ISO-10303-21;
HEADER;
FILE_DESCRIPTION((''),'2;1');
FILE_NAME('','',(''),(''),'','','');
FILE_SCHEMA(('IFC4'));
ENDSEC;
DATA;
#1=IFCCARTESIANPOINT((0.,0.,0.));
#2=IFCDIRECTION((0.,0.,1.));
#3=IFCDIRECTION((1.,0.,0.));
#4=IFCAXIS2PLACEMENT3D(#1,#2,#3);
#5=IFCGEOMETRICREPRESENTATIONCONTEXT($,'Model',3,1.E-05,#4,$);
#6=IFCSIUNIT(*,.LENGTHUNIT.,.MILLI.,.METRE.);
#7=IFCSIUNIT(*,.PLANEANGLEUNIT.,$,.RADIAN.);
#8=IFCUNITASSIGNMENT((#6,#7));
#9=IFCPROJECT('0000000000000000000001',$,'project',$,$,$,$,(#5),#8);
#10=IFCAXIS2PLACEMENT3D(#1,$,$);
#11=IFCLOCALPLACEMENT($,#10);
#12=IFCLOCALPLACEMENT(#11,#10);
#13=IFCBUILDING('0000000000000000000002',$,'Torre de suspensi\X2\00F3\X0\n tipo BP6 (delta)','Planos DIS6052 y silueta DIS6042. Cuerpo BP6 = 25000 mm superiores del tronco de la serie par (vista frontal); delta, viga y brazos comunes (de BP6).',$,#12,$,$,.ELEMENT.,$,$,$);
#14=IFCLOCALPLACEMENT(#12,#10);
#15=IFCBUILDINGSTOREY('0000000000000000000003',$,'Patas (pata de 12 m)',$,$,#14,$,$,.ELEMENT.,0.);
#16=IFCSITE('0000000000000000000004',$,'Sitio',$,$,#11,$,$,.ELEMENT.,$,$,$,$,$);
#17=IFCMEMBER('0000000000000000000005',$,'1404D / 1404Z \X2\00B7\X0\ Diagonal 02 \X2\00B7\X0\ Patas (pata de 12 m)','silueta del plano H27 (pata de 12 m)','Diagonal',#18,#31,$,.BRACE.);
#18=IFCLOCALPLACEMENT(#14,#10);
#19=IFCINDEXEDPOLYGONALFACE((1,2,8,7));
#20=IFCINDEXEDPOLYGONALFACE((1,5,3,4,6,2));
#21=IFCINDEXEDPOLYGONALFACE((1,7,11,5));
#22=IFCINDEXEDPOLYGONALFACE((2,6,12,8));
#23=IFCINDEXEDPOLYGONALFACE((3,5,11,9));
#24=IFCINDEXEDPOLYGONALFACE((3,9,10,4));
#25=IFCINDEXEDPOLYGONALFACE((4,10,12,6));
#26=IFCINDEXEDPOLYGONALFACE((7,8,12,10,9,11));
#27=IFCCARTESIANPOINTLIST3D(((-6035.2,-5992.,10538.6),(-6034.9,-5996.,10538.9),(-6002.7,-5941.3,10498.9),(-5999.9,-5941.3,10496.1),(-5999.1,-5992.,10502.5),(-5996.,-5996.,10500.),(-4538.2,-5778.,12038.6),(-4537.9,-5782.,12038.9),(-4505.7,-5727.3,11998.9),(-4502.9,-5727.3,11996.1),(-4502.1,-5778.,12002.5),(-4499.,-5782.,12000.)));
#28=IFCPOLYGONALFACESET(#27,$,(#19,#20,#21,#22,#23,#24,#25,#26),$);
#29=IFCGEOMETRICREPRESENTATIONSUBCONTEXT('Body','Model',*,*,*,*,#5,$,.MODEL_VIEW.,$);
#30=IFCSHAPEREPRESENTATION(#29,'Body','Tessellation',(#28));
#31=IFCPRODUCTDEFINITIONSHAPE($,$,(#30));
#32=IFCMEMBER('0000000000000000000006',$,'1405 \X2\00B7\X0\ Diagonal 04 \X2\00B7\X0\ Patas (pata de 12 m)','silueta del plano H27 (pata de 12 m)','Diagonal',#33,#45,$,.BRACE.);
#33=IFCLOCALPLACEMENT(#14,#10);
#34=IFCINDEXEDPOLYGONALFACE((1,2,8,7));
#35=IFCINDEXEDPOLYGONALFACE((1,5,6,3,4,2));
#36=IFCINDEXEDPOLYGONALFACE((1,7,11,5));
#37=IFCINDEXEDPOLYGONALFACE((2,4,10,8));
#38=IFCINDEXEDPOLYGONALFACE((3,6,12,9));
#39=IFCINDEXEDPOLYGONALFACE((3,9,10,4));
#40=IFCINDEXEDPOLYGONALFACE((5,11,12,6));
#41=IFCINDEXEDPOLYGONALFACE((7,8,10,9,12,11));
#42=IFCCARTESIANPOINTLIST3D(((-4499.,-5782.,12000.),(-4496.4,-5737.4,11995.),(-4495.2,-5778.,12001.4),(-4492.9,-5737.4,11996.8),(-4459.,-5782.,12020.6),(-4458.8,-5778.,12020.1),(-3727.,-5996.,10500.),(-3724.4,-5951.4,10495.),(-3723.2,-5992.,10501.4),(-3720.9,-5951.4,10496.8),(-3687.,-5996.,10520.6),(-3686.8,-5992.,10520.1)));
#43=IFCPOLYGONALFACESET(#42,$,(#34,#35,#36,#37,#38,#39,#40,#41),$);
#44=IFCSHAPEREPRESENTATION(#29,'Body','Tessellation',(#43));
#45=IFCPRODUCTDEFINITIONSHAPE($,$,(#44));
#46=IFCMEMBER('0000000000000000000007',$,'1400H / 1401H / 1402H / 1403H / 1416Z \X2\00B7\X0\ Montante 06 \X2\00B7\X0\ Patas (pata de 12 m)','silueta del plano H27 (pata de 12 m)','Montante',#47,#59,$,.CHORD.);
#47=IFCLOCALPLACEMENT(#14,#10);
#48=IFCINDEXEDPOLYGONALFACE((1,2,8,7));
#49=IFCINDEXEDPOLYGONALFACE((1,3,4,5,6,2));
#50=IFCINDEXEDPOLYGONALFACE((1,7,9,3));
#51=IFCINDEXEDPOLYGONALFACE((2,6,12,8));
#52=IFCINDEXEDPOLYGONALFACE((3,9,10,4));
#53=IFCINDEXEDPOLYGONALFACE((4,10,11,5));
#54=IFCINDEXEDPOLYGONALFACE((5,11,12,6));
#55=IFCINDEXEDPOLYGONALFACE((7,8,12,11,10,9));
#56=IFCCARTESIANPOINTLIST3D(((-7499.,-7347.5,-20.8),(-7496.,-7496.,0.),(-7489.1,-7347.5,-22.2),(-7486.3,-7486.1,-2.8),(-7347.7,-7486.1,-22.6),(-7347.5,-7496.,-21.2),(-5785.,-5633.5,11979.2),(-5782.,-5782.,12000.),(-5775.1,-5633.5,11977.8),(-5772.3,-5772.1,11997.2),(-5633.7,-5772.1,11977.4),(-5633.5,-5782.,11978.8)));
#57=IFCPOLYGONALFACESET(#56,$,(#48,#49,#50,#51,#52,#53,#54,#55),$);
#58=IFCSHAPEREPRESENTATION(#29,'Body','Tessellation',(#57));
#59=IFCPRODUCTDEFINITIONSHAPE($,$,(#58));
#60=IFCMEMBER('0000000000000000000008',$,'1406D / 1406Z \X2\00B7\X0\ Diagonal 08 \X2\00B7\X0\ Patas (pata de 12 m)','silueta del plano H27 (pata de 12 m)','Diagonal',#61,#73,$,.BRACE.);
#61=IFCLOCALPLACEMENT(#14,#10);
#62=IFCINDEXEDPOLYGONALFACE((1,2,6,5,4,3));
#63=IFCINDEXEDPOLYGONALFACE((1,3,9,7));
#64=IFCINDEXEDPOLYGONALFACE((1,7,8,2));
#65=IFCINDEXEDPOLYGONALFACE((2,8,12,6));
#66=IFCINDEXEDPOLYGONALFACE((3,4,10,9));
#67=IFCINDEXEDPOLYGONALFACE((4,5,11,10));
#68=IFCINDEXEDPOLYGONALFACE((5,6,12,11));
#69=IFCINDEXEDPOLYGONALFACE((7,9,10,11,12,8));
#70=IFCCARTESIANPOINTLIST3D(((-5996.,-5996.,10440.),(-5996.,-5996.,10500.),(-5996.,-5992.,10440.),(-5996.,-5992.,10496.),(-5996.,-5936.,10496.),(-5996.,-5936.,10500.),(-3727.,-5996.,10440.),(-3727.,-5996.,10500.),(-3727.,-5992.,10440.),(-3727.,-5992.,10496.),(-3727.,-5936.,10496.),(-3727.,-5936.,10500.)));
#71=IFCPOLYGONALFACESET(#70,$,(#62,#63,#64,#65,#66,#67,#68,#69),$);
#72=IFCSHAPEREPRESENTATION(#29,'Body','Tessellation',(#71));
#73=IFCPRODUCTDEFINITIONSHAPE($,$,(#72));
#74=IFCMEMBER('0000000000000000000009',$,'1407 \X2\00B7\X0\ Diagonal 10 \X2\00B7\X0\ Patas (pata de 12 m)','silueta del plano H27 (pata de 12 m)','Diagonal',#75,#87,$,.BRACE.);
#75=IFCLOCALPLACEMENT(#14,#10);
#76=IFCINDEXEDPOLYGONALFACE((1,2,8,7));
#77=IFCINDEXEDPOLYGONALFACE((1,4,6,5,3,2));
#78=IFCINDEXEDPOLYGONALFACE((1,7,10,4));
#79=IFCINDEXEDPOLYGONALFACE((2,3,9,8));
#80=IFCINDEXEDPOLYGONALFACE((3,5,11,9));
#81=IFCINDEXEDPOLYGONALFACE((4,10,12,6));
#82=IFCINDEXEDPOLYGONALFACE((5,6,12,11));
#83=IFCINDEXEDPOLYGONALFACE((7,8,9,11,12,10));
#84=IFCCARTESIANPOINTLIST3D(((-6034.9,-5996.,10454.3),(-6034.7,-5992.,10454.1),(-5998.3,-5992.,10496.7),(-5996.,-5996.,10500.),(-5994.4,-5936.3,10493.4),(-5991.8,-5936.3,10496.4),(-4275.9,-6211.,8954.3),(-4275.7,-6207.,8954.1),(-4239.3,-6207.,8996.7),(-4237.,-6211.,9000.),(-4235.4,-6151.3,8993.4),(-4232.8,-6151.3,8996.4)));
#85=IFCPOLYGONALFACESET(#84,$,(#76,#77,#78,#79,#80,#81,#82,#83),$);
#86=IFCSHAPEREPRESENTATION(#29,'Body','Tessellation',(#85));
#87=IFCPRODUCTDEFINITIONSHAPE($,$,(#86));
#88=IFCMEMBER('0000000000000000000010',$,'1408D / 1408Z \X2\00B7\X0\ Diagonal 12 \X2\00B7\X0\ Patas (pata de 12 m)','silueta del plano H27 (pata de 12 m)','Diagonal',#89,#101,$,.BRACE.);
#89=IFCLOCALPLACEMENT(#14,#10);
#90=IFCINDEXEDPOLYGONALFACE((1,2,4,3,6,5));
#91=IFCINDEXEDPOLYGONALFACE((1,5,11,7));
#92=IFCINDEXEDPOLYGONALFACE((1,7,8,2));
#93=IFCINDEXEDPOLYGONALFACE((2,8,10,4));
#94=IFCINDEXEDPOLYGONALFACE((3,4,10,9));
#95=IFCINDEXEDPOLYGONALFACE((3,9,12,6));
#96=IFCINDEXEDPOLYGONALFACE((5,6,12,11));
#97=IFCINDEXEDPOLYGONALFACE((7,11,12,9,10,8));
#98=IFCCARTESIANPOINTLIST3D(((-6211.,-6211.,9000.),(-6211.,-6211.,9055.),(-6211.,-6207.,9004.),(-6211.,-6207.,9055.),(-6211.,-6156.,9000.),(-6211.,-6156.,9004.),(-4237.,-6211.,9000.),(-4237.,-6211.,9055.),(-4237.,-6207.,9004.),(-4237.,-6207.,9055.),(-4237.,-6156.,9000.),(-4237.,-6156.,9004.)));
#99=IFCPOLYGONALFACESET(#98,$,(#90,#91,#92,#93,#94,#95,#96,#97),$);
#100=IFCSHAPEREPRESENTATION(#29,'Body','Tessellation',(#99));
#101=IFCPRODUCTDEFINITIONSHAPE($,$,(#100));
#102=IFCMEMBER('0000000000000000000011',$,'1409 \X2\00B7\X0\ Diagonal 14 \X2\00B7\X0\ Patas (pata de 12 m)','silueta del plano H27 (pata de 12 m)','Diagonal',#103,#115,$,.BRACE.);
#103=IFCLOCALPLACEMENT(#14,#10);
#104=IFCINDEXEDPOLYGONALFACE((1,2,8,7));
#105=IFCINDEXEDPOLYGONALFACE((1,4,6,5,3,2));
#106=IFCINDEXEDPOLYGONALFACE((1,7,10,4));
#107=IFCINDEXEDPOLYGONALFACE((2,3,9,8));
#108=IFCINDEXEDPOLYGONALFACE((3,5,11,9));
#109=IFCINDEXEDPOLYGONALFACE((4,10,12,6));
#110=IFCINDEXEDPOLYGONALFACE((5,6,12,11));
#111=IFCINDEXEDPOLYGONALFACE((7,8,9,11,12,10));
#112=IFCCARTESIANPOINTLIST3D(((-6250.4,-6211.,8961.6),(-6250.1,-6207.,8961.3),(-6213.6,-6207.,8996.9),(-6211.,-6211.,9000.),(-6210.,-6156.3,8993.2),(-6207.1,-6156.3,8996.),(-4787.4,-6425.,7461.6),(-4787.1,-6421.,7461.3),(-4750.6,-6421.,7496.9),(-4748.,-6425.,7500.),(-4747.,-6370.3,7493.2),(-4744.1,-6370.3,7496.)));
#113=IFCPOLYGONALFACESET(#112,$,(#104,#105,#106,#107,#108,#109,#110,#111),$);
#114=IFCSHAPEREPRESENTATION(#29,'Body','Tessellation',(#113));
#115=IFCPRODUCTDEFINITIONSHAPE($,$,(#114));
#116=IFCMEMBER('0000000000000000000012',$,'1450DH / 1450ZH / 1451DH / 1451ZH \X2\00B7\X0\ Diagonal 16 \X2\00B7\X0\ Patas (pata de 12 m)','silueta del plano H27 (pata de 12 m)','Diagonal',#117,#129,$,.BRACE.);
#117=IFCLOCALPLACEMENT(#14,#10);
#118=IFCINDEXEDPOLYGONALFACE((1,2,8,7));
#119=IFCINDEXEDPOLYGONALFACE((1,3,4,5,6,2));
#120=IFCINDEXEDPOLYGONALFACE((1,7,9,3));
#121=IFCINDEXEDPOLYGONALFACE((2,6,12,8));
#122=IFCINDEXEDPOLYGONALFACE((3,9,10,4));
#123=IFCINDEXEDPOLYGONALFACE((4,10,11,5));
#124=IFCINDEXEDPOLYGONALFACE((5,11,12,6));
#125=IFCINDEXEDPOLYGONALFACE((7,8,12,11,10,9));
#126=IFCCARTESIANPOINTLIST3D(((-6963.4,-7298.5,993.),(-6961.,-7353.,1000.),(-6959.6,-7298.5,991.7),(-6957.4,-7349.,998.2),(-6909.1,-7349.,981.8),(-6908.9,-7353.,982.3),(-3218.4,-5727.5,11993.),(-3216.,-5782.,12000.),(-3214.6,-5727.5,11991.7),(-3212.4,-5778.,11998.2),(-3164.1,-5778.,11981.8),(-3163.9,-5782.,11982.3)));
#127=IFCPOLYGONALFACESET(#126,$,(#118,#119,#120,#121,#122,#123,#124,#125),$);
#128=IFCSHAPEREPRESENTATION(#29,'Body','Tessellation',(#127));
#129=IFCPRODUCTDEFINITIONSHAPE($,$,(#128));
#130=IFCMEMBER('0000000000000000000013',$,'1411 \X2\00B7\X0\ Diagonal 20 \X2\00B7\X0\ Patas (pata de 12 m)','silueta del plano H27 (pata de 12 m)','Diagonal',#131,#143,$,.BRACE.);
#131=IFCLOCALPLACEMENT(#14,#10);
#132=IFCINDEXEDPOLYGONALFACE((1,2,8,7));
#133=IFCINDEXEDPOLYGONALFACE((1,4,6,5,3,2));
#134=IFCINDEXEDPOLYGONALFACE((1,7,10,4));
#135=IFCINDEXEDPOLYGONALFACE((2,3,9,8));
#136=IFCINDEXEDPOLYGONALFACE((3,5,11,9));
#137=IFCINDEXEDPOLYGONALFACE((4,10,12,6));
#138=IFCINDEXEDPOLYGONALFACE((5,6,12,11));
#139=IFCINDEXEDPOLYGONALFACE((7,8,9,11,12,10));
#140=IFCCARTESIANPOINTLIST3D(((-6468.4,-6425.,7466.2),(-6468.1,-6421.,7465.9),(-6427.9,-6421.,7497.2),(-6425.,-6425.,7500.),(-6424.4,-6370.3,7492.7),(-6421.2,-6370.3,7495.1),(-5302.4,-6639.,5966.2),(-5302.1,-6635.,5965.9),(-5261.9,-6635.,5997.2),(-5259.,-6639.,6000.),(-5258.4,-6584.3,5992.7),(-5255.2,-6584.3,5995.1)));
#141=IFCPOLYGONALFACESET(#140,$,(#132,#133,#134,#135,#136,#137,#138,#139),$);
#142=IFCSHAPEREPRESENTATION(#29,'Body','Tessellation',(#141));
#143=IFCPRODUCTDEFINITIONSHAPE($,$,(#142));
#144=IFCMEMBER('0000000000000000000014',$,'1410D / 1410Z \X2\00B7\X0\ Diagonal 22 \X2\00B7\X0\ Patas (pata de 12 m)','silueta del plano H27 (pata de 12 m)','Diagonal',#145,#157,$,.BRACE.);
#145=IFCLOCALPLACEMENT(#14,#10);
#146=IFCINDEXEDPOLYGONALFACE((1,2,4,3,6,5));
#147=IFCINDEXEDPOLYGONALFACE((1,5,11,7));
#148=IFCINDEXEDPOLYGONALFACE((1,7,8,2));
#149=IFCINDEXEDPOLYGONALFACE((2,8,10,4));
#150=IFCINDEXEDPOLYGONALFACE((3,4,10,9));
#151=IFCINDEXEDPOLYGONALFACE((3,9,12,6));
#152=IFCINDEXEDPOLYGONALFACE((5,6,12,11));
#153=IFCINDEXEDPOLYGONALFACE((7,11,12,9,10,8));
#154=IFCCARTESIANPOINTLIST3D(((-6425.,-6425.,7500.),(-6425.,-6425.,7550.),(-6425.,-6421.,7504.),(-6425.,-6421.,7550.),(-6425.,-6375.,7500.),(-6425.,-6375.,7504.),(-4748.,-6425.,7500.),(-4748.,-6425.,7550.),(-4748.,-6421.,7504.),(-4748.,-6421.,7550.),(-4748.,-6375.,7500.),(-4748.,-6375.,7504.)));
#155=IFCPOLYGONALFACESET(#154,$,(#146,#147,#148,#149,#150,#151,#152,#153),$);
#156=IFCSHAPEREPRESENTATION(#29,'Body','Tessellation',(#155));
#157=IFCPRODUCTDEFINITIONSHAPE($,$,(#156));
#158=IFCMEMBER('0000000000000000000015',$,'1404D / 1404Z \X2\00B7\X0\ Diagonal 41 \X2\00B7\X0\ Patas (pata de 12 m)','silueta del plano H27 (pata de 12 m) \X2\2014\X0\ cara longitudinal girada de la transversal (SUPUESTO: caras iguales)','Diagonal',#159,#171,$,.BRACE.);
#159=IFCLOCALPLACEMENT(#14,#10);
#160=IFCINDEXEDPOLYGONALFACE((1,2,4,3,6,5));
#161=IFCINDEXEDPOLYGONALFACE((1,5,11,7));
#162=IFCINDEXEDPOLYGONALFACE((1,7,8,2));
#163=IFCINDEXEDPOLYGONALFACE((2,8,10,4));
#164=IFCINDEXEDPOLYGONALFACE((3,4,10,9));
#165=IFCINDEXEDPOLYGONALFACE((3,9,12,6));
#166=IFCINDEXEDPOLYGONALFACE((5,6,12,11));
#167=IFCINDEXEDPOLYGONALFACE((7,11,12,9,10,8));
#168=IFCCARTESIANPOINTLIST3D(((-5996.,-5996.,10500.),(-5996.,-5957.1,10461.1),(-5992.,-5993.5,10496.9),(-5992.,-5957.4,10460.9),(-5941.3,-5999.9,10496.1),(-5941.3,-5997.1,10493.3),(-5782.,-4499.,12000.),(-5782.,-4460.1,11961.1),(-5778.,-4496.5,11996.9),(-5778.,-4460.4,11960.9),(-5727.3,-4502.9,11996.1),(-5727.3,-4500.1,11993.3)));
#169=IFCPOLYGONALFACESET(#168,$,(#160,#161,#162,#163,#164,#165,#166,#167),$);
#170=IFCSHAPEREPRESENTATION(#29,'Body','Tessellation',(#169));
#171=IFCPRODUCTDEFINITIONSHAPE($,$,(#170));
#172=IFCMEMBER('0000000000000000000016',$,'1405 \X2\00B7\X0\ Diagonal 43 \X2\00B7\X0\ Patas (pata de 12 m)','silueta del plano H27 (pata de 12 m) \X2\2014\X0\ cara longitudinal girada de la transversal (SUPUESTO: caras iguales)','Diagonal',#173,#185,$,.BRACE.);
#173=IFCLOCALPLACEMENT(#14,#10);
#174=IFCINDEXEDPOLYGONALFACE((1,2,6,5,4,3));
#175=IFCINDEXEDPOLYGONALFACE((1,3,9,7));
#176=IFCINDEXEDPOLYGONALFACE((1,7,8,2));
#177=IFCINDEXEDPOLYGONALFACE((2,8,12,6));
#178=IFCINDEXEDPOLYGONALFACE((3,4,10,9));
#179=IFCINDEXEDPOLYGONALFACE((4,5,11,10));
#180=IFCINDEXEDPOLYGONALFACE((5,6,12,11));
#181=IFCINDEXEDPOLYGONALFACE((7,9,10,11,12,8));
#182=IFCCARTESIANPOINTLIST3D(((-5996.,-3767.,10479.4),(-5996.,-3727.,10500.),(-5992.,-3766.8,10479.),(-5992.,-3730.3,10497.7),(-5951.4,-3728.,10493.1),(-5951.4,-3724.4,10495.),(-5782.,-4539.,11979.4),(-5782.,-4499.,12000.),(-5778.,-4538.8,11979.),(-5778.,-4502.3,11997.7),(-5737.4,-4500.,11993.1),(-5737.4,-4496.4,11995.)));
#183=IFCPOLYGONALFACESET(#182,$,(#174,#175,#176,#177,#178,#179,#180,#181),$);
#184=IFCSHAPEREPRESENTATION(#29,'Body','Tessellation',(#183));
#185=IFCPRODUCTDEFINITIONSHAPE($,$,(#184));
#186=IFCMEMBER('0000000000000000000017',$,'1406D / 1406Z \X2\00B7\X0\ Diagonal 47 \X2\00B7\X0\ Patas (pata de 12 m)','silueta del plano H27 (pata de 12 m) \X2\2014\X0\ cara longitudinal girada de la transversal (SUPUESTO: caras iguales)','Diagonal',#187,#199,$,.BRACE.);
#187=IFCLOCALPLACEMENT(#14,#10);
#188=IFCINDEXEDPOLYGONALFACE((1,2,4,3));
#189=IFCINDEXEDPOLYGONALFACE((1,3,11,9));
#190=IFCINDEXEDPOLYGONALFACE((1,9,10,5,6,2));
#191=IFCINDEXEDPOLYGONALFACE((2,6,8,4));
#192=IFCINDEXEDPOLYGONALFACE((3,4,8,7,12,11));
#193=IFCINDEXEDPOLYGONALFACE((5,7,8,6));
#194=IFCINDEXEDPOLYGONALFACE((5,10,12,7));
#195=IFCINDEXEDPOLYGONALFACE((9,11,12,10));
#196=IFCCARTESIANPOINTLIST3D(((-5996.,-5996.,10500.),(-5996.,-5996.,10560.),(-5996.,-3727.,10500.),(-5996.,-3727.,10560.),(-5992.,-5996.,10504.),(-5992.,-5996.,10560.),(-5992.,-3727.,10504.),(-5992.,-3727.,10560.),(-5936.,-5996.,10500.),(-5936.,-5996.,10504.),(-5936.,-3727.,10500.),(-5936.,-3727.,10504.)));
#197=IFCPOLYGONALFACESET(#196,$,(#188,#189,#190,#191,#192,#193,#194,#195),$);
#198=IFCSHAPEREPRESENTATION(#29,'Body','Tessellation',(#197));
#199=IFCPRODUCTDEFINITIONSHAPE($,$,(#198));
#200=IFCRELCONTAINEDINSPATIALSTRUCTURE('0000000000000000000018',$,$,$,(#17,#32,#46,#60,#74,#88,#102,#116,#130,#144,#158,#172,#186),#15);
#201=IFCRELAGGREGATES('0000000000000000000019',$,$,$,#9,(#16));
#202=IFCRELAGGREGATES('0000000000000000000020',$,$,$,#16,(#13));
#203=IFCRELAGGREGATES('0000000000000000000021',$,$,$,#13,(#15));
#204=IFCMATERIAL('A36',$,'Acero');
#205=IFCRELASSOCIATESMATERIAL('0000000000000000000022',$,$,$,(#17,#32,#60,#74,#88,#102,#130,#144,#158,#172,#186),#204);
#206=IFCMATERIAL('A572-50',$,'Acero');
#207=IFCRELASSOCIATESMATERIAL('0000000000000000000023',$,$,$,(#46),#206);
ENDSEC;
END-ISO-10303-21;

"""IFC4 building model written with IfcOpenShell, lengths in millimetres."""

from ifc_helpers import new_model, si_unit, frame, frame_2d, origin, origin_with_axes, place, context, subcontext, project, spatial, l_section, extrude, material, element, save


model = new_model("IFC4")

# Units and contexts
model_context = context("Model", 3, precision=1e-05, world=origin_with_axes())
body_context = subcontext(model_context, "Body", "Model", "MODEL_VIEW")
ifc_project = project(units=[si_unit("LENGTHUNIT", "METRE", prefix="MILLI"), si_unit("PLANEANGLEUNIT", "RADIAN")], contexts=[model_context])

# Site, building, storey
site_placement = place(None, origin())
site = spatial("IfcSite", under=ifc_project, at=site_placement, Name="Sitio", CompositionType="ELEMENT")
building_placement = place(site_placement, origin())
building = spatial("IfcBuilding", under=site, at=building_placement, Name="Torre de suspensión tipo BP6 (delta)", Description="Planos DIS6052 y silueta DIS6042. Cuerpo BP6 = 25000 mm superiores del tronco de la serie par (vista frontal); delta, viga y brazos comunes (de BP6).", CompositionType="ELEMENT")
storey_placement = place(building_placement, origin())
storey = spatial("IfcBuildingStorey", under=building, at=storey_placement, Name="Patas (pata de 12 m)", CompositionType="ELEMENT", Elevation=0.0)

# Members
ifc_material_1 = material(Name="A36", Category="Acero")
member_1_placement = place(storey_placement, frame((-5996.0, -5996.0, 10500.0), z_axis=(0.702824, 0.100471, 0.704233), x_axis=(-0.070972, 0.99494, -0.071114)))
element("IfcMember", 1, at=member_1_placement, inside=storey, material=ifc_material_1, Name="1404D / 1404Z · Diagonal 02 · Patas (pata de 12 m)", Description="silueta del plano H27 (pata de 12 m)", ObjectType="Diagonal", PredefinedType="BRACE", context=body_context, shape_type="SweptSolid", body=[
    extrude(l_section(Depth=55.0, Width=55.0, Thickness=4.0, at=frame_2d((27.5, 27.5))), None, (0.0, 0.0, 1.0), 2130.0),
])
member_2_placement = place(storey_placement, frame((-4499.0, -5782.0, 12000.0), z_axis=(0.453978, -0.125844, -0.882081), x_axis=(0.057588, 0.99205, -0.111894)))
element("IfcMember", 2, at=member_2_placement, inside=storey, material=ifc_material_1, Name="1405 · Diagonal 04 · Patas (pata de 12 m)", Description="silueta del plano H27 (pata de 12 m)", ObjectType="Diagonal", PredefinedType="BRACE", context=body_context, shape_type="SweptSolid", body=[
    extrude(l_section(Depth=45.0, Width=45.0, Thickness=4.0, at=frame_2d((22.5, 22.5))), None, (0.0, 0.0, 1.0), 1700.5),
])
ifc_material_2 = material(Name="A572-50", Category="Acero")
member_3_placement = place(storey_placement, frame((-5782.0, -5782.0, 12000.0), z_axis=(-0.140006, -0.140006, -0.980202), x_axis=(-0.019797, 0.990151, -0.138599)))
element("IfcMember", 3, at=member_3_placement, inside=storey, material=ifc_material_2, Name="1400H / 1401H / 1402H / 1403H / 1416Z · Montante 06 · Patas (pata de 12 m)", Description="silueta del plano H27 (pata de 12 m)", ObjectType="Montante", PredefinedType="CHORD", context=body_context, shape_type="SweptSolid", body=[
    extrude(l_section(Depth=150.0, Width=150.0, Thickness=10.0, at=frame_2d((75.0, 75.0))), None, (0.0, 0.0, 1.0), 12242.4),
])
member_4_placement = place(storey_placement, frame((-3727.0, -5996.0, 10500.0), z_axis=(-1.0, 0.0, 0.0), x_axis=(0.0, 1.0, 0.0)))
element("IfcMember", 4, at=member_4_placement, inside=storey, material=ifc_material_1, Name="1406D / 1406Z · Diagonal 08 · Patas (pata de 12 m)", Description="silueta del plano H27 (pata de 12 m)", ObjectType="Diagonal", PredefinedType="BRACE", context=body_context, shape_type="SweptSolid", body=[
    extrude(l_section(Depth=60.0, Width=60.0, Thickness=4.0, at=frame_2d((30.0, 30.0))), None, (0.0, 0.0, 1.0), 2269.0),
])
member_5_placement = place(storey_placement, frame((-4237.0, -6211.0, 9000.0), z_axis=(-0.757633, 0.092604, 0.646077), x_axis=(0.070463, 0.995703, -0.060088)))
element("IfcMember", 5, at=member_5_placement, inside=storey, material=ifc_material_1, Name="1407 · Diagonal 10 · Patas (pata de 12 m)", Description="silueta del plano H27 (pata de 12 m)", ObjectType="Diagonal", PredefinedType="BRACE", context=body_context, shape_type="SweptSolid", body=[
    extrude(l_section(Depth=60.0, Width=60.0, Thickness=4.0, at=frame_2d((30.0, 30.0))), None, (0.0, 0.0, 1.0), 2321.7),
])
member_6_placement = place(storey_placement, frame((-6211.0, -6211.0, 9000.0), z_axis=(1.0, 0.0, 0.0), x_axis=(0.0, 1.0, 0.0)))
element("IfcMember", 6, at=member_6_placement, inside=storey, material=ifc_material_1, Name="1408D / 1408Z · Diagonal 12 · Patas (pata de 12 m)", Description="silueta del plano H27 (pata de 12 m)", ObjectType="Diagonal", PredefinedType="BRACE", context=body_context, shape_type="SweptSolid", body=[
    extrude(l_section(Depth=55.0, Width=55.0, Thickness=4.0, at=frame_2d((27.5, 27.5))), None, (0.0, 0.0, 1.0), 1974.0),
])
member_7_placement = place(storey_placement, frame((-4748.0, -6425.0, 7500.0), z_axis=(-0.694609, 0.101604, 0.712176), x_axis=(0.070942, 0.994825, -0.072736)))
element("IfcMember", 7, at=member_7_placement, inside=storey, material=ifc_material_1, Name="1409 · Diagonal 14 · Patas (pata de 12 m)", Description="silueta del plano H27 (pata de 12 m)", ObjectType="Diagonal", PredefinedType="BRACE", context=body_context, shape_type="SweptSolid", body=[
    extrude(l_section(Depth=55.0, Width=55.0, Thickness=4.0, at=frame_2d((27.5, 27.5))), None, (0.0, 0.0, 1.0), 2106.2),
])
member_8_placement = place(storey_placement, frame((-3216.0, -5782.0, 12000.0), z_axis=(-0.319383, -0.133979, -0.938107), x_axis=(-0.04318, 0.990984, -0.12683)))
element("IfcMember", 8, at=member_8_placement, inside=storey, Name="1450DH / 1450ZH / 1451DH / 1451ZH · Diagonal 16 · Patas (pata de 12 m)", Description="silueta del plano H27 (pata de 12 m)", ObjectType="Diagonal", PredefinedType="BRACE", context=body_context, shape_type="SweptSolid", body=[
    extrude(l_section(Depth=55.0, Width=55.0, Thickness=4.0, at=frame_2d((27.5, 27.5))), None, (0.0, 0.0, 1.0), 11725.7),
])
member_9_placement = place(storey_placement, frame((-5259.0, -6639.0, 6000.0), z_axis=(-0.609865, 0.111931, 0.784561), x_axis=(0.068694, 0.993716, -0.088372)))
element("IfcMember", 9, at=member_9_placement, inside=storey, material=ifc_material_1, Name="1411 · Diagonal 20 · Patas (pata de 12 m)", Description="silueta del plano H27 (pata de 12 m)", ObjectType="Diagonal", PredefinedType="BRACE", context=body_context, shape_type="SweptSolid", body=[
    extrude(l_section(Depth=55.0, Width=55.0, Thickness=4.0, at=frame_2d((27.5, 27.5))), None, (0.0, 0.0, 1.0), 1911.9),
])
member_10_placement = place(storey_placement, frame((-6425.0, -6425.0, 7500.0), z_axis=(1.0, 0.0, 0.0), x_axis=(0.0, 1.0, 0.0)))
element("IfcMember", 10, at=member_10_placement, inside=storey, material=ifc_material_1, Name="1410D / 1410Z · Diagonal 22 · Patas (pata de 12 m)", Description="silueta del plano H27 (pata de 12 m)", ObjectType="Diagonal", PredefinedType="BRACE", context=body_context, shape_type="SweptSolid", body=[
    extrude(l_section(Depth=50.0, Width=50.0, Thickness=4.0, at=frame_2d((25.0, 25.0))), None, (0.0, 0.0, 1.0), 1677.0),
])
member_11_placement = place(storey_placement, frame((-5996.0, -5996.0, 10500.0), z_axis=(0.100471, 0.702824, 0.704233), x_axis=(0.99494, -0.070972, -0.071114)))
element("IfcMember", 11, at=member_11_placement, inside=storey, material=ifc_material_1, Name="1404D / 1404Z · Diagonal 41 · Patas (pata de 12 m)", Description="silueta del plano H27 (pata de 12 m) — cara longitudinal girada de la transversal (SUPUESTO: caras iguales)", ObjectType="Diagonal", PredefinedType="BRACE", context=body_context, shape_type="SweptSolid", body=[
    extrude(l_section(Depth=55.0, Width=55.0, Thickness=4.0, at=frame_2d((27.5, 27.5))), None, (0.0, 0.0, 1.0), 2130.0),
])
member_12_placement = place(storey_placement, frame((-5782.0, -4499.0, 12000.0), z_axis=(-0.125844, 0.453978, -0.882081), x_axis=(0.99205, 0.057588, -0.111894)))
element("IfcMember", 12, at=member_12_placement, inside=storey, material=ifc_material_1, Name="1405 · Diagonal 43 · Patas (pata de 12 m)", Description="silueta del plano H27 (pata de 12 m) — cara longitudinal girada de la transversal (SUPUESTO: caras iguales)", ObjectType="Diagonal", PredefinedType="BRACE", context=body_context, shape_type="SweptSolid", body=[
    extrude(l_section(Depth=45.0, Width=45.0, Thickness=4.0, at=frame_2d((22.5, 22.5))), None, (0.0, 0.0, 1.0), 1700.5),
])
member_13_placement = place(storey_placement, frame((-5996.0, -3727.0, 10500.0), z_axis=(0.0, -1.0, 0.0), x_axis=(1.0, 0.0, 0.0)))
element("IfcMember", 13, at=member_13_placement, inside=storey, material=ifc_material_1, Name="1406D / 1406Z · Diagonal 47 · Patas (pata de 12 m)", Description="silueta del plano H27 (pata de 12 m) — cara longitudinal girada de la transversal (SUPUESTO: caras iguales)", ObjectType="Diagonal", PredefinedType="BRACE", context=body_context, shape_type="SweptSolid", body=[
    extrude(l_section(Depth=60.0, Width=60.0, Thickness=4.0, at=frame_2d((30.0, 30.0))), None, (0.0, 0.0, 1.0), 2269.0),
])

save(model, "model.ifc")
